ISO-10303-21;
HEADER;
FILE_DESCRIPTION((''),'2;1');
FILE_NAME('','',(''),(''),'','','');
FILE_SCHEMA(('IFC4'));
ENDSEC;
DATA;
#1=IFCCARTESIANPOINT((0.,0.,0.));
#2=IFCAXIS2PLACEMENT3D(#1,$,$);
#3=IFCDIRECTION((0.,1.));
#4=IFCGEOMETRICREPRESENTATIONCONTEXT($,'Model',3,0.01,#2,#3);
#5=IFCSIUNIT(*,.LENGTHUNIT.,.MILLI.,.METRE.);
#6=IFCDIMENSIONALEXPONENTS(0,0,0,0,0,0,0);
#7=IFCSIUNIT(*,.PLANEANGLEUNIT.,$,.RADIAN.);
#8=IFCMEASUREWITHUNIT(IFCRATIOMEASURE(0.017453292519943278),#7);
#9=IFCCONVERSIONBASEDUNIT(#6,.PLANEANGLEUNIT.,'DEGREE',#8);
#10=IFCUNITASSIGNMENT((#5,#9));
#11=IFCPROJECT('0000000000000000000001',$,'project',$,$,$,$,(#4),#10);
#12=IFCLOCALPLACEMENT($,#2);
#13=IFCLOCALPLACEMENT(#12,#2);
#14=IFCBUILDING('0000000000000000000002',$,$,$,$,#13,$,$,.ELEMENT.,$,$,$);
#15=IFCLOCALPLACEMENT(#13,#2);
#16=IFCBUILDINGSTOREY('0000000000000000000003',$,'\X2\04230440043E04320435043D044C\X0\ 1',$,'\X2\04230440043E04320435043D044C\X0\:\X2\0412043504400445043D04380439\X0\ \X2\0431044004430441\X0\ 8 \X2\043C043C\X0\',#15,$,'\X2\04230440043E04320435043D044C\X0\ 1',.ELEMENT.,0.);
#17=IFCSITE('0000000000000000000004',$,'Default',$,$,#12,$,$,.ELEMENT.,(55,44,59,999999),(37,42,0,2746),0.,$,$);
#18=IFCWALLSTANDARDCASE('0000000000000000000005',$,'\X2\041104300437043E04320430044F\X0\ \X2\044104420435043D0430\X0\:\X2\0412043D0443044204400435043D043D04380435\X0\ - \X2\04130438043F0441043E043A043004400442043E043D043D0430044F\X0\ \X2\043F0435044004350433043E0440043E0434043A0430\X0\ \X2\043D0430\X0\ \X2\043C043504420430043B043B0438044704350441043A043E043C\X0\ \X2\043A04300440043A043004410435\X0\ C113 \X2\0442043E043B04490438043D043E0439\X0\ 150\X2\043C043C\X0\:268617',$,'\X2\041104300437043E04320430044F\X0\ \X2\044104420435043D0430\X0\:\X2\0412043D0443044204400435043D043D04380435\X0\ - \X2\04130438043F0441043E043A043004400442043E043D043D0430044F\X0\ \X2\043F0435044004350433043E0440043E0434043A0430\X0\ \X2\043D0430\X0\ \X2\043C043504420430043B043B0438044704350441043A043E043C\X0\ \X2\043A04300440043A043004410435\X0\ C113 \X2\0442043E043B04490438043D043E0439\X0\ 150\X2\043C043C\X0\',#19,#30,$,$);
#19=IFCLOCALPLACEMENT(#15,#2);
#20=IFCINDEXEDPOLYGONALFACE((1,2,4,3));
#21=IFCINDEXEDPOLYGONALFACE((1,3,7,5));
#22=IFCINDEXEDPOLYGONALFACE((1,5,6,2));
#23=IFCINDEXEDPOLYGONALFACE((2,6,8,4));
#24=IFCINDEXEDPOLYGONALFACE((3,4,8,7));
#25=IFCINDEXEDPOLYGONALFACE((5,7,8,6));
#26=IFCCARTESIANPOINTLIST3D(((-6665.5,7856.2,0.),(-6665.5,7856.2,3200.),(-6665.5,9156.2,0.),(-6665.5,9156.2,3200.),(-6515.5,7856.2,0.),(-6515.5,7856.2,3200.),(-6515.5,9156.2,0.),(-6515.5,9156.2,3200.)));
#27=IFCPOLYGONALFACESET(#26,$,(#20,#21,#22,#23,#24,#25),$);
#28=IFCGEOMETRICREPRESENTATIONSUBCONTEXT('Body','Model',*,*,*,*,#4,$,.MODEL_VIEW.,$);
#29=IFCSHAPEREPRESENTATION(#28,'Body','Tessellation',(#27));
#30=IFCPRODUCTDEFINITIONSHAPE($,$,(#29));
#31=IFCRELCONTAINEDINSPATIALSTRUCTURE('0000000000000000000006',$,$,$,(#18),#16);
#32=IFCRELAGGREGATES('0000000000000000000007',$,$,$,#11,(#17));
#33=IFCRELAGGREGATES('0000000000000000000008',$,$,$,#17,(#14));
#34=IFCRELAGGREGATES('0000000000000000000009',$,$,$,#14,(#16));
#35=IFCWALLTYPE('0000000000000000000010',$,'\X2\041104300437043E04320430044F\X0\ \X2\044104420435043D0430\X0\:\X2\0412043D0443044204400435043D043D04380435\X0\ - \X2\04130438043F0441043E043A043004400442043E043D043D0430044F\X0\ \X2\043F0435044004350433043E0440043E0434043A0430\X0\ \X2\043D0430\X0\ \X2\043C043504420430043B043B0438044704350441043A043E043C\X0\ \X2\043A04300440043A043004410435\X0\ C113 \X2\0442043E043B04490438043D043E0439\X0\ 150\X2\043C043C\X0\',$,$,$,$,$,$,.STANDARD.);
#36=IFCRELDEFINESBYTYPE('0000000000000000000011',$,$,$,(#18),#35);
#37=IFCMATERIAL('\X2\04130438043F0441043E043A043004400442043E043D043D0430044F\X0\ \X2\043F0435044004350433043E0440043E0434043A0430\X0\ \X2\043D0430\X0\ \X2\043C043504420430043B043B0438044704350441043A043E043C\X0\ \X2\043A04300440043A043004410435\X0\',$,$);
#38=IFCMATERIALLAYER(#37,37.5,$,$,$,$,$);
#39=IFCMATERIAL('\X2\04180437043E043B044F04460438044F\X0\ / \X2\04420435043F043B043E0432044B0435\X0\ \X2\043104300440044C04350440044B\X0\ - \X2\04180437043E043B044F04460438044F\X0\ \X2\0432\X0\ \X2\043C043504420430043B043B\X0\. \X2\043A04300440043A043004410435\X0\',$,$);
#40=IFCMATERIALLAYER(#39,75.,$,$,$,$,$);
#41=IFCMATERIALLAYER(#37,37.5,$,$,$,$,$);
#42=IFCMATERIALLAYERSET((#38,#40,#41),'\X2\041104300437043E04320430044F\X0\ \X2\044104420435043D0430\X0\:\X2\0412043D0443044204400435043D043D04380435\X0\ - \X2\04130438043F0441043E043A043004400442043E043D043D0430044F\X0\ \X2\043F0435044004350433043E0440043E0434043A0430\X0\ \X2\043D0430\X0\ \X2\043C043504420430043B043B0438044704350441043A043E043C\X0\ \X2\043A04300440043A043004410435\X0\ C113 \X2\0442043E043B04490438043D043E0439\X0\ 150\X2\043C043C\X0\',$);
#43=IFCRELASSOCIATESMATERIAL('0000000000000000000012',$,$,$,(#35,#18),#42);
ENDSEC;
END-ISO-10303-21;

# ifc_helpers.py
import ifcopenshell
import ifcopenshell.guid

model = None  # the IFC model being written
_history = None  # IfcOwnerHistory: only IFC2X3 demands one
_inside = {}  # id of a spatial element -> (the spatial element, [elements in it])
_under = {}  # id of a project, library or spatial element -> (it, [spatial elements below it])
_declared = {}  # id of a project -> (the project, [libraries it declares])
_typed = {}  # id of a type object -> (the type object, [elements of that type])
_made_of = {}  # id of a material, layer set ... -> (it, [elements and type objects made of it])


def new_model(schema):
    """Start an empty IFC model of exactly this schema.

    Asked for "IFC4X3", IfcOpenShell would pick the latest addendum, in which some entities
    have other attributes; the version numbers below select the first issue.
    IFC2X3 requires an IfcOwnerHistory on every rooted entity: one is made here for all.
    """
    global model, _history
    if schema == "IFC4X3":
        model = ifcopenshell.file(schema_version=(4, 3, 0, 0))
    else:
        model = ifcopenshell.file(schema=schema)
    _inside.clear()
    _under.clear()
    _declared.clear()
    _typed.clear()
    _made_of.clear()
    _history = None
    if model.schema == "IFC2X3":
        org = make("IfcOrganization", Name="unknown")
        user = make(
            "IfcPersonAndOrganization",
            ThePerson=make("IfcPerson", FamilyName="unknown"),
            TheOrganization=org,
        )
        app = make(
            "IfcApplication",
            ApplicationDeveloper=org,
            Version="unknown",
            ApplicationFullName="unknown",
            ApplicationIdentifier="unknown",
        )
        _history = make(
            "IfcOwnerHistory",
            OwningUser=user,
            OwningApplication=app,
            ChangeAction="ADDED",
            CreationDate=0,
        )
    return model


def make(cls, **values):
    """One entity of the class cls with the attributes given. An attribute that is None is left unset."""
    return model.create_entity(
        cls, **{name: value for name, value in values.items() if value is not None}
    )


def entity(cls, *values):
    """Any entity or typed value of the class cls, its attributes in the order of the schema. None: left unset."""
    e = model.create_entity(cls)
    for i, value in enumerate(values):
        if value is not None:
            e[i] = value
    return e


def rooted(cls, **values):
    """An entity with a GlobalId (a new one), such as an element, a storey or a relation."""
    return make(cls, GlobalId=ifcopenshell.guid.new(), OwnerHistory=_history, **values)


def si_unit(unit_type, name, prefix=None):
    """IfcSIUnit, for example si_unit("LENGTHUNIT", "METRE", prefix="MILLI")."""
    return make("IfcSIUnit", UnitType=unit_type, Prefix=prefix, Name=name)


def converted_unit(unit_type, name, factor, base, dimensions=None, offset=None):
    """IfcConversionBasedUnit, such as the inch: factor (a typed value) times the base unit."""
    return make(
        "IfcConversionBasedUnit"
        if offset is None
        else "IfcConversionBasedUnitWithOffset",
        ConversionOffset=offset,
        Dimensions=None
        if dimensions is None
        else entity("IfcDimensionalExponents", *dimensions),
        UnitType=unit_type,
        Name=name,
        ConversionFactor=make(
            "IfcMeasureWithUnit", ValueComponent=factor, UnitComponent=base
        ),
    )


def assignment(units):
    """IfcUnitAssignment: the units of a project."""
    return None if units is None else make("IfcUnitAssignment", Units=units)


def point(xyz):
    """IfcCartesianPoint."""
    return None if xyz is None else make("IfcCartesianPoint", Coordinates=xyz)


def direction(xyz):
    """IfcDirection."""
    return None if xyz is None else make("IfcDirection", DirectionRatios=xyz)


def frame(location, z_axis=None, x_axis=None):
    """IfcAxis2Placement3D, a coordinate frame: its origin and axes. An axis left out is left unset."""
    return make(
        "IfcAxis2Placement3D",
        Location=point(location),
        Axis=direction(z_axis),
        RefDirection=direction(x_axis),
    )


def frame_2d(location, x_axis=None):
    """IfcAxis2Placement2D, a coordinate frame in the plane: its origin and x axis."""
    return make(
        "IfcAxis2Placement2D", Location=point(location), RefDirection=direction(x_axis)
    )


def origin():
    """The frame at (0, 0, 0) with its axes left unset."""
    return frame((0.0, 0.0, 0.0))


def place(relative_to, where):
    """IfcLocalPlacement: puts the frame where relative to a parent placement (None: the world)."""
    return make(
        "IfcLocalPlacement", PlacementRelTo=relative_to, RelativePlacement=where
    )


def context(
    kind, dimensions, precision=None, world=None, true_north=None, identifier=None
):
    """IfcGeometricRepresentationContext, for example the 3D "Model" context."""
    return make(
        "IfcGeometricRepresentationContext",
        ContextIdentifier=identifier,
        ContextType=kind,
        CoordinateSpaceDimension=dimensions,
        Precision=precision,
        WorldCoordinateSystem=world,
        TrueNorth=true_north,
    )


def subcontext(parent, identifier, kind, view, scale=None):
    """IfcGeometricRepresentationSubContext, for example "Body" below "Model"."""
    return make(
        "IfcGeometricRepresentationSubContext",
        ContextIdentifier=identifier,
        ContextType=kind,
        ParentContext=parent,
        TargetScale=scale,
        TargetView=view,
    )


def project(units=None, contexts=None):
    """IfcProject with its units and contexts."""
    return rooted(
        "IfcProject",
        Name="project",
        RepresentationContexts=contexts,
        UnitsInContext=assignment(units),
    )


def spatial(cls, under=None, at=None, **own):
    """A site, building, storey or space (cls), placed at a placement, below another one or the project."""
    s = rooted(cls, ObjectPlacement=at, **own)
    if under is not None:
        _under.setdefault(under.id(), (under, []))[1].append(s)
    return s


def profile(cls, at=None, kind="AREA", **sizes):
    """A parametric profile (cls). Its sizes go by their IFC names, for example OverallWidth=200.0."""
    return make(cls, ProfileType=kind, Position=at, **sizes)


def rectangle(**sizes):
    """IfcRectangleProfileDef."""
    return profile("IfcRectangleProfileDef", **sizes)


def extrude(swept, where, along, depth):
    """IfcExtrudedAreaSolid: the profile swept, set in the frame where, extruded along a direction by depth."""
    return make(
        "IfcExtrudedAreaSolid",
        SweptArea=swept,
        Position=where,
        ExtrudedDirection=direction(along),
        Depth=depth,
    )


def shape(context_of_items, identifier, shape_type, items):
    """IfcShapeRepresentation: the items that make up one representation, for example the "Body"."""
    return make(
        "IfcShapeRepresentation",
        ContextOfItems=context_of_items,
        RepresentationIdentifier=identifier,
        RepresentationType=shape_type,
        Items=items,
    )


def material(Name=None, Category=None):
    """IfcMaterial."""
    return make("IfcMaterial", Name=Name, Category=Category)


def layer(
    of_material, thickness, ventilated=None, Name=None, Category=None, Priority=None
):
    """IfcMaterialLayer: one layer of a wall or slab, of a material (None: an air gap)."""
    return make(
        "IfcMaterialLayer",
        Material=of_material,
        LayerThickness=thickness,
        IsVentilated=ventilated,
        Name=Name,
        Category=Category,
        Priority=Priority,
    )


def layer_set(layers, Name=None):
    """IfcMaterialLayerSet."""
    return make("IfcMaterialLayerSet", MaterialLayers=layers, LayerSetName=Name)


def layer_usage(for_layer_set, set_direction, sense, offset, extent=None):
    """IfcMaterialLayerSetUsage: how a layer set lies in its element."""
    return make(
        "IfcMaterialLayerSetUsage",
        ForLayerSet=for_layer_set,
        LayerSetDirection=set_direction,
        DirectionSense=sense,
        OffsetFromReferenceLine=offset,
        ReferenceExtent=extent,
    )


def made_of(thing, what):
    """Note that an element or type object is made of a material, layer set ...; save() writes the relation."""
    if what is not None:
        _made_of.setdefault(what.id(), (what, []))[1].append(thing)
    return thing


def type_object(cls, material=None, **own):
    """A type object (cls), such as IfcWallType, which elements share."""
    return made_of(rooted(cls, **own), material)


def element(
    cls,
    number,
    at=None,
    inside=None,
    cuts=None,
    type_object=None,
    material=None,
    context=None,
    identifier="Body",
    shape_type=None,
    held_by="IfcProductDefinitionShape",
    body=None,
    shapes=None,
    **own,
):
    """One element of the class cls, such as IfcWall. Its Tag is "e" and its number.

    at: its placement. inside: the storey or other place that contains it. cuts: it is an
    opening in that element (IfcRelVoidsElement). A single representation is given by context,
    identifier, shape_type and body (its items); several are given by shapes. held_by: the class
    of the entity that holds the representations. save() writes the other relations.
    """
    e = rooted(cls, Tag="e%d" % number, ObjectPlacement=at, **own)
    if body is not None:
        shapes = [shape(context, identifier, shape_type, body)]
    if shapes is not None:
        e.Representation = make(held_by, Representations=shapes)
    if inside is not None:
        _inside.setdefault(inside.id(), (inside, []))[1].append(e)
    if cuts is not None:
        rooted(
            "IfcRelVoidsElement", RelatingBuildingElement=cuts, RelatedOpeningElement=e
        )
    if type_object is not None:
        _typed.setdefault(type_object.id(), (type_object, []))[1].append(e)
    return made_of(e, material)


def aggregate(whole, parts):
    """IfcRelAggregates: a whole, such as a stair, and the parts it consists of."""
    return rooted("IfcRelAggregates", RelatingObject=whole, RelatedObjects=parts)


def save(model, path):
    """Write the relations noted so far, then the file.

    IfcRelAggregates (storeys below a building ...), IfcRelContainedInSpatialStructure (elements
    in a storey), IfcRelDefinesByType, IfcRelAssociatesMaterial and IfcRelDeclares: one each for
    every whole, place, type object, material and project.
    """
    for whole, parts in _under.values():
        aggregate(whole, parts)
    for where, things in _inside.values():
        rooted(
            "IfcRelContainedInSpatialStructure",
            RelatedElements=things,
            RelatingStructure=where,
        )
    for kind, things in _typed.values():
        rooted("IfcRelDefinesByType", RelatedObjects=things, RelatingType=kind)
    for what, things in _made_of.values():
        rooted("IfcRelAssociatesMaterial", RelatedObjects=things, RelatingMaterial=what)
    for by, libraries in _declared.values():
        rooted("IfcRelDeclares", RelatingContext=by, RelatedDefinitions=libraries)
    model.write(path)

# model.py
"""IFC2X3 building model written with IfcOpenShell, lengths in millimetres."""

from ifc_helpers import new_model, entity, si_unit, converted_unit, direction, frame, frame_2d, origin, place, context, subcontext, project, spatial, rectangle, extrude, material, layer, layer_set, layer_usage, type_object, element, save


model = new_model("IFC2X3")

# Units and contexts
model_context = context("Model", 3, precision=0.01, world=origin(), true_north=direction((0.0, 1.0)))
body_context = subcontext(model_context, "Body", "Model", "MODEL_VIEW")
ifc_project = project(units=[si_unit("LENGTHUNIT", "METRE", prefix="MILLI"), converted_unit("PLANEANGLEUNIT", "DEGREE", entity("IfcRatioMeasure", 0.017453292519943278), si_unit("PLANEANGLEUNIT", "RADIAN"), dimensions=[0, 0, 0, 0, 0, 0, 0])], contexts=[model_context])

# Site, building, storey
site_placement = place(None, origin())
site = spatial("IfcSite", under=ifc_project, at=site_placement, Name="Default", CompositionType="ELEMENT", RefLatitude=(55, 44, 59, 999999), RefLongitude=(37, 42, 0, 2746), RefElevation=0.0)
building_placement = place(site_placement, origin())
building = spatial("IfcBuilding", under=site, at=building_placement, CompositionType="ELEMENT")
storey_placement = place(building_placement, origin())
storey = spatial("IfcBuildingStorey", under=building, at=storey_placement, Name="Уровень 1", ObjectType="Уровень:Верхний брус 8 мм", LongName="Уровень 1", CompositionType="ELEMENT", Elevation=0.0)

# Shared definitions
ifc_material_1 = material(Name="Гипсокартонная перегородка на металлическом каркасе")
ifc_layer_1 = layer(ifc_material_1, 37.5)
ifc_material_2 = material(Name="Изоляция / тепловые барьеры - Изоляция в металл. каркасе")
ifc_layer_2 = layer(ifc_material_2, 75.0)
ifc_layer_3 = layer(ifc_material_1, 37.5)
ifc_layer_set_1 = layer_set([ifc_layer_1, ifc_layer_2, ifc_layer_3], Name="Базовая стена:Внутренние - Гипсокартонная перегородка на металлическом каркасе C113 толщиной 150мм")
wall_type_1 = type_object("IfcWallType", Name="Базовая стена:Внутренние - Гипсокартонная перегородка на металлическом каркасе C113 толщиной 150мм", PredefinedType="STANDARD", material=ifc_layer_set_1)

# Wall
ifc_layer_usage_1 = layer_usage(ifc_layer_set_1, "AXIS2", "NEGATIVE", 75.0)
wall_1_placement = place(storey_placement, frame((-6590.5, 9156.2, 0.0), z_axis=(0.0, 0.0, 1.0), x_axis=(0.0, -1.0, 0.0)))
element("IfcWallStandardCase", 1, at=wall_1_placement, inside=storey, type_object=wall_type_1, material=ifc_layer_usage_1, Name="Базовая стена:Внутренние - Гипсокартонная перегородка на металлическом каркасе C113 толщиной 150мм:268617", ObjectType="Базовая стена:Внутренние - Гипсокартонная перегородка на металлическом каркасе C113 толщиной 150мм", context=body_context, shape_type="SweptSolid", body=[
    extrude(rectangle(XDim=1300.0, YDim=150.0, at=frame_2d((650.0, 0.0), x_axis=(-1.0, 0.0))), origin(), (0.0, 0.0, 1.0), 3200.0),
])

save(model, "model.ifc")
